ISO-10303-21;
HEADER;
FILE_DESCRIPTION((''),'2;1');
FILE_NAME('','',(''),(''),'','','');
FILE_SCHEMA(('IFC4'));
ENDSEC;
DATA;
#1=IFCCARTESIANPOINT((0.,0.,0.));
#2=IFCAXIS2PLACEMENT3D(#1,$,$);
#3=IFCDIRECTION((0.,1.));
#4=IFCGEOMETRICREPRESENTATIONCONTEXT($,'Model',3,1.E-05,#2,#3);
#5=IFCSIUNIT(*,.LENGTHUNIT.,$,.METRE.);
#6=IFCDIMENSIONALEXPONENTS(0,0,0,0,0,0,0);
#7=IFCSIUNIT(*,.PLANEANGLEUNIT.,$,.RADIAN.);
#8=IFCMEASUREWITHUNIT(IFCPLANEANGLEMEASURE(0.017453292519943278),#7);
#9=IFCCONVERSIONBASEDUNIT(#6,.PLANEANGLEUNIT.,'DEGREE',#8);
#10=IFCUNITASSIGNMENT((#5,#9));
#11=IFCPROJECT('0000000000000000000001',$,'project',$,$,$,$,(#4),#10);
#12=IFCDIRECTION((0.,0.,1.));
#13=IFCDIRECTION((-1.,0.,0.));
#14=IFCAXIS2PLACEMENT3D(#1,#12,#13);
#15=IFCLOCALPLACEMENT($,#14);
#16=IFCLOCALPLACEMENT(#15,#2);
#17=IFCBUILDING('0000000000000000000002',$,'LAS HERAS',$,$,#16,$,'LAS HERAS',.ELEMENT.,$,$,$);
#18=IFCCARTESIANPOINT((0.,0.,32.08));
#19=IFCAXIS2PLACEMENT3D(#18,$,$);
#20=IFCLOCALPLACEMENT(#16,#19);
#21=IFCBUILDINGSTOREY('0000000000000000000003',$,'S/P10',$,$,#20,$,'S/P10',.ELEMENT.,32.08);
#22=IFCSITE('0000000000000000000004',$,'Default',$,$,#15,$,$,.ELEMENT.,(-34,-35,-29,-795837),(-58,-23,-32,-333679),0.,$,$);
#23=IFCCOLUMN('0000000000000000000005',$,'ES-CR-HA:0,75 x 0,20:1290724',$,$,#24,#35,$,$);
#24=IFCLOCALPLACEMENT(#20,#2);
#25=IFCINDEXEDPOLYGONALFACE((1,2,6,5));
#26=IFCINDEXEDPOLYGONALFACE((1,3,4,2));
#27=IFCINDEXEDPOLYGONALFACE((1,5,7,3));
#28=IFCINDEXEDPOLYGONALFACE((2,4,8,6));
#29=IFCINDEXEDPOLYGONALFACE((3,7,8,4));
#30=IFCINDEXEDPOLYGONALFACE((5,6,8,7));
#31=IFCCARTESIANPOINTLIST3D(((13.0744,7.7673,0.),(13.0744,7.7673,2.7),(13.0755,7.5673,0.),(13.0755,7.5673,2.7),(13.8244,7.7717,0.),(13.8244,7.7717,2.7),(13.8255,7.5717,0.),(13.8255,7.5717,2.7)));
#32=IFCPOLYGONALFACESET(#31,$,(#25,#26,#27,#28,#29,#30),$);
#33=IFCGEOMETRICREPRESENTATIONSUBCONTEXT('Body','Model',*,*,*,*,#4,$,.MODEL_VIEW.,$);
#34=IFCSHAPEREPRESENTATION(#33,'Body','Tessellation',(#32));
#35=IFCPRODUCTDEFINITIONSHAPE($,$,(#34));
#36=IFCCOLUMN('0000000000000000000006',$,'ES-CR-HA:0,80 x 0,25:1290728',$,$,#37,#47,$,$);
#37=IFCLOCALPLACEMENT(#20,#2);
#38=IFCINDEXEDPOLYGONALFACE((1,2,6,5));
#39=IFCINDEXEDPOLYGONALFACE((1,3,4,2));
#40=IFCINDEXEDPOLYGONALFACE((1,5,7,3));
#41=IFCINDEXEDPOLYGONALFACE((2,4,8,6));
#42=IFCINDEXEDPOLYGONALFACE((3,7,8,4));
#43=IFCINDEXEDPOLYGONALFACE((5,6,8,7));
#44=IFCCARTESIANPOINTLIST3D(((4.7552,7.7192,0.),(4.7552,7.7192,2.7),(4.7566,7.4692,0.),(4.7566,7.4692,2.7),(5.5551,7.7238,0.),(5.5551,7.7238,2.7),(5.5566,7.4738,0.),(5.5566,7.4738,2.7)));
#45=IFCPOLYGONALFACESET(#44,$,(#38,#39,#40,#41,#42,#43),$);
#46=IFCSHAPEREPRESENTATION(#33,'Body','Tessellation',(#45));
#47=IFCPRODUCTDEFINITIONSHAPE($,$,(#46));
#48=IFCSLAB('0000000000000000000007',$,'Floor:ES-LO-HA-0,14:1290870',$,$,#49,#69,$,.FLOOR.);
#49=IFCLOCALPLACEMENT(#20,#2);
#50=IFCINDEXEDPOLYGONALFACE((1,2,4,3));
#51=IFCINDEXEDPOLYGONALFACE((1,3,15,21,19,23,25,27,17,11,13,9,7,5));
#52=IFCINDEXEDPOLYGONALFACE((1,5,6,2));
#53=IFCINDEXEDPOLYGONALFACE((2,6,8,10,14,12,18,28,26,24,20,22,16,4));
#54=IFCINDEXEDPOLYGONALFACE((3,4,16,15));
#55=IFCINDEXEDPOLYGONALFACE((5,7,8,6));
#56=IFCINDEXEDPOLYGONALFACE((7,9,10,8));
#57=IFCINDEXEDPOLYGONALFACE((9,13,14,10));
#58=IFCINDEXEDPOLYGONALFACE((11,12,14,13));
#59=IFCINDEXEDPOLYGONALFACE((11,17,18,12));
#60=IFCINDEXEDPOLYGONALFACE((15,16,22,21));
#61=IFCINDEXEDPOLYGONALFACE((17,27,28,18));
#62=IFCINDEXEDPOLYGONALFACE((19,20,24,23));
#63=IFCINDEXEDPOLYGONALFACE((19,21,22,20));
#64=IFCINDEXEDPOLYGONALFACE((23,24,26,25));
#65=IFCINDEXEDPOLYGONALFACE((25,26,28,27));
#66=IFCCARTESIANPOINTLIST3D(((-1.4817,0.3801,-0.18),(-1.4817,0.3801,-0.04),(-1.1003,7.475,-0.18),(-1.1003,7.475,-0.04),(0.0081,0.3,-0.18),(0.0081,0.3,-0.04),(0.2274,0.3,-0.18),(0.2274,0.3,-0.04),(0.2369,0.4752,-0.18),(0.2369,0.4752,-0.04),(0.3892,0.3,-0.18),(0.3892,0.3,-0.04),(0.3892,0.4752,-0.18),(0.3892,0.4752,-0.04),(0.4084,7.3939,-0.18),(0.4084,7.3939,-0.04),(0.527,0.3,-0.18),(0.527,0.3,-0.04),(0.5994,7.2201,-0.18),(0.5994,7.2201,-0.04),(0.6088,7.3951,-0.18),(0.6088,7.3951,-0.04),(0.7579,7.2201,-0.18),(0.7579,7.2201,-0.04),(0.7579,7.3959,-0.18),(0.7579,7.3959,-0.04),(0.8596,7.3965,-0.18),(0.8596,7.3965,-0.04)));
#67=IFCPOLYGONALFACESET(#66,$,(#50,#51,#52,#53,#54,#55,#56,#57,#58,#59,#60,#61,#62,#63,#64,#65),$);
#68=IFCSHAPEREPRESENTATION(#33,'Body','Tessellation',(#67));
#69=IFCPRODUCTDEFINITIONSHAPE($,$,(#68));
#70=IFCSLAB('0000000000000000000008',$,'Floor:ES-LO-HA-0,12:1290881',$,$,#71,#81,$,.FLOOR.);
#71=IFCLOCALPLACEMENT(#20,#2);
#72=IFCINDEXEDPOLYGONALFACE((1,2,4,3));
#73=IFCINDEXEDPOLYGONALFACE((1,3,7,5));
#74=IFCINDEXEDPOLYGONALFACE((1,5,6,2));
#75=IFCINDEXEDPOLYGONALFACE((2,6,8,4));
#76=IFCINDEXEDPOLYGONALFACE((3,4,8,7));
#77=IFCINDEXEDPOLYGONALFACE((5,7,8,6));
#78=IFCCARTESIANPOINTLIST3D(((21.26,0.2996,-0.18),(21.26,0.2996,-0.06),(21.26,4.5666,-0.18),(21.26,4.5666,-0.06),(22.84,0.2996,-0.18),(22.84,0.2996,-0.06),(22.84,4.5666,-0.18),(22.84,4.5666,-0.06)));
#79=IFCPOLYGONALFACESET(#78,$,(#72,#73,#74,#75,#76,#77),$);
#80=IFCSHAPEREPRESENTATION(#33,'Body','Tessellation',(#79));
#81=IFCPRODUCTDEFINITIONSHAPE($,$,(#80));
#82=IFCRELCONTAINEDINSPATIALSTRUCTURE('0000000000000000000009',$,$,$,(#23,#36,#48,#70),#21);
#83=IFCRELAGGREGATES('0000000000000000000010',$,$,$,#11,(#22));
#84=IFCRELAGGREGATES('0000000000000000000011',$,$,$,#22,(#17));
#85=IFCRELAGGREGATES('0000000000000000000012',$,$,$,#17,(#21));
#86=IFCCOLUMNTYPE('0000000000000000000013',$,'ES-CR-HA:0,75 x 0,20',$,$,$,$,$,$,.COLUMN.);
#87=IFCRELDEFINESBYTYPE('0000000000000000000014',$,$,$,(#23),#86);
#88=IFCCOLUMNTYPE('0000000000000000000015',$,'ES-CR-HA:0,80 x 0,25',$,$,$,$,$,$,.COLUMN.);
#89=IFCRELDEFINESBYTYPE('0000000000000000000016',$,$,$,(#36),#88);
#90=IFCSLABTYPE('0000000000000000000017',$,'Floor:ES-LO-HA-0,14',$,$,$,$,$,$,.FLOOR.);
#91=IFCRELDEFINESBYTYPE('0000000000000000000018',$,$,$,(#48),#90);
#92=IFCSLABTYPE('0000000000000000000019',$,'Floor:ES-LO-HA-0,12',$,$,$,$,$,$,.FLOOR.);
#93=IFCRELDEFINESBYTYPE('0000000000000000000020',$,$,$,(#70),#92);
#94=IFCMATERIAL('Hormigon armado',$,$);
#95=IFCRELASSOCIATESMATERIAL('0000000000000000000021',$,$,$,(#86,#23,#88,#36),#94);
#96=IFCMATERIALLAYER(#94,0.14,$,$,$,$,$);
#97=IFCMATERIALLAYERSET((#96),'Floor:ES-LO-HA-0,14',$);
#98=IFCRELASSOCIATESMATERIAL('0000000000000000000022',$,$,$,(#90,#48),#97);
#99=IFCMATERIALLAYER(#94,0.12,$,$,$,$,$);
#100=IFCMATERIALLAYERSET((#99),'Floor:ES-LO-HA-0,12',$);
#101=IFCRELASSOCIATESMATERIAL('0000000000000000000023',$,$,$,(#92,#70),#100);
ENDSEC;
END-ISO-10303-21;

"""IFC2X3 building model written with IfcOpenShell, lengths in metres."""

from ifc_helpers import new_model, entity, si_unit, converted_unit, direction, frame, frame_2d, origin, place, context, subcontext, project, spatial, polyline, rectangle, outline, extrude, source, transform, mapped, material, layer, layer_set, layer_usage, type_object, type_shapes, element, save


model = new_model("IFC2X3")

# Units and contexts
model_context = context("Model", 3, precision=1e-05, world=origin(), true_north=direction((0.0, 1.0)))
body_context = subcontext(model_context, "Body", "Model", "MODEL_VIEW")
ifc_project = project(units=[si_unit("LENGTHUNIT", "METRE"), converted_unit("PLANEANGLEUNIT", "DEGREE", entity("IfcPlaneAngleMeasure", 0.017453292519943278), si_unit("PLANEANGLEUNIT", "RADIAN"), dimensions=[0, 0, 0, 0, 0, 0, 0])], contexts=[model_context])

# Site, building, storey
site_placement = place(None, frame((0.0, 0.0, 0.0), z_axis=(0.0, 0.0, 1.0), x_axis=(-1.0, 0.0, 0.0)))
site = spatial("IfcSite", under=ifc_project, at=site_placement, Name="Default", CompositionType="ELEMENT", RefLatitude=(-34, -35, -29, -795837), RefLongitude=(-58, -23, -32, -333679), RefElevation=0.0)
building_placement = place(site_placement, origin())
building = spatial("IfcBuilding", under=site, at=building_placement, Name="LAS HERAS", LongName="LAS HERAS", CompositionType="ELEMENT")
storey_placement = place(building_placement, frame((0.0, 0.0, 32.08)))
storey = spatial("IfcBuildingStorey", under=building, at=storey_placement, Name="S/P10", LongName="S/P10", CompositionType="ELEMENT", Elevation=32.08)

# Columns
ifc_material = material(Name="Hormigon armado")
column_type_1 = type_object("IfcColumnType", Name="ES-CR-HA:0,75 x 0,20", PredefinedType="COLUMN", material=ifc_material)
shared_shape_1 = source(origin(), body_context, "Body", "SweptSolid", [
    extrude(rectangle(XDim=0.75, YDim=0.2, at=frame_2d((0.0, 0.0), x_axis=(1.0, 0.0))), frame((13.4499, 7.6695, 32.08), z_axis=(0.0, 0.0, 1.0), x_axis=(-0.999983, -0.005788, 0.0)), (0.0, 0.0, 1.0), 2.7),
])
type_shapes(column_type_1, [shared_shape_1])
column_1_placement = place(storey_placement, frame((0.0, 0.0, -32.08)))
element("IfcColumn", 1, at=column_1_placement, inside=storey, type_object=column_type_1, material=ifc_material, Name="ES-CR-HA:0,75 x 0,20:1290724", context=body_context, shape_type="MappedRepresentation", body=[
    mapped(shared_shape_1, transform((0.0, 0.0, 0.0), scale=1.0)),
])
column_type_2 = type_object("IfcColumnType", Name="ES-CR-HA:0,80 x 0,25", PredefinedType="COLUMN", material=ifc_material)
shared_shape_2 = source(origin(), body_context, "Body", "SweptSolid", [
    extrude(rectangle(XDim=0.8, YDim=0.25, at=frame_2d((0.0, 0.0), x_axis=(1.0, 0.0))), frame((5.1559, 7.5965, 32.08), z_axis=(0.0, 0.0, 1.0), x_axis=(-0.999983, -0.005788, 0.0)), (0.0, 0.0, 1.0), 2.7),
])
type_shapes(column_type_2, [shared_shape_2])
column_2_placement = place(storey_placement, frame((0.0, 0.0, -32.08)))
element("IfcColumn", 2, at=column_2_placement, inside=storey, type_object=column_type_2, material=ifc_material, Name="ES-CR-HA:0,80 x 0,25:1290728", context=body_context, shape_type="MappedRepresentation", body=[
    mapped(shared_shape_2, transform((0.0, 0.0, 0.0), scale=1.0)),
])

# Slab, openings
ifc_layer_1 = layer(ifc_material, 0.14)
ifc_layer_set_1 = layer_set([ifc_layer_1], Name="Floor:ES-LO-HA-0,14")
ifc_layer_usage_1 = layer_usage(ifc_layer_set_1, "AXIS3", "POSITIVE", 0.0)
slab_type_1 = type_object("IfcSlabType", Name="Floor:ES-LO-HA-0,14", PredefinedType="FLOOR", material=ifc_layer_set_1)
slab_1_placement = place(storey_placement, origin())
slab_1 = element("IfcSlab", 3, at=slab_1_placement, inside=storey, type_object=slab_type_1, material=ifc_layer_usage_1, Name="Floor:ES-LO-HA-0,14:1290870", PredefinedType="FLOOR", context=body_context, shape_type="SweptSolid", body=[
    extrude(outline(polyline([(-0.2993, -3.5591), (-0.1615, -3.5591), (-0.1615, -3.3839), (-0.0091, -3.3839), (0.0003, -3.5591), (0.2196, -3.5591), (1.7094, -3.479), (1.328, 3.6159), (-0.1807, 3.5348), (-0.3811, 3.536), (-0.3717, 3.3611), (-0.5302, 3.3611), (-0.5302, 3.5368), (-0.6319, 3.5374), (-0.2993, -3.5591)])), frame((0.2277, 3.8591, -0.04), z_axis=(0.0, 0.0, -1.0), x_axis=(-1.0, 0.0, 0.0)), (0.0, 0.0, 1.0), 0.14),
])
opening_1_placement = place(slab_1_placement, origin())
element("IfcOpeningElement", 4, at=opening_1_placement, cuts=slab_1, ObjectType="Opening", context=body_context, shape_type="SweptSolid", body=[
    extrude(outline(polyline([(0.2369, 0.4752), (0.2274, 0.3), (0.3892, 0.3), (0.3892, 0.4752), (0.2369, 0.4752)])), frame((0.0, 0.0, -0.04)), (0.0, 0.0, -1.0), 0.14),
])
opening_2_placement = place(slab_1_placement, origin())
element("IfcOpeningElement", 5, at=opening_2_placement, cuts=slab_1, ObjectType="Opening", context=body_context, shape_type="SweptSolid", body=[
    extrude(outline(polyline([(0.7579, 7.2201), (0.7579, 7.3959), (0.6088, 7.3951), (0.5994, 7.2201), (0.7579, 7.2201)])), frame((0.0, 0.0, -0.04)), (0.0, 0.0, -1.0), 0.14),
])

# Slab
ifc_layer_2 = layer(ifc_material, 0.12)
ifc_layer_set_2 = layer_set([ifc_layer_2], Name="Floor:ES-LO-HA-0,12")
ifc_layer_usage_2 = layer_usage(ifc_layer_set_2, "AXIS3", "POSITIVE", 0.0)
slab_type_2 = type_object("IfcSlabType", Name="Floor:ES-LO-HA-0,12", PredefinedType="FLOOR", material=ifc_layer_set_2)
slab_2_placement = place(storey_placement, origin())
element("IfcSlab", 6, at=slab_2_placement, inside=storey, type_object=slab_type_2, material=ifc_layer_usage_2, Name="Floor:ES-LO-HA-0,12:1290881", PredefinedType="FLOOR", context=body_context, shape_type="SweptSolid", body=[
    extrude(rectangle(XDim=4.2671, YDim=1.58, at=frame_2d((0.0, 0.0), x_axis=(1.0, 0.0))), frame((22.05, 2.4331, -0.06), z_axis=(0.0, 0.0, -1.0), x_axis=(0.0, 1.0, 0.0)), (0.0, 0.0, 1.0), 0.12),
])

save(model, "model.ifc")
